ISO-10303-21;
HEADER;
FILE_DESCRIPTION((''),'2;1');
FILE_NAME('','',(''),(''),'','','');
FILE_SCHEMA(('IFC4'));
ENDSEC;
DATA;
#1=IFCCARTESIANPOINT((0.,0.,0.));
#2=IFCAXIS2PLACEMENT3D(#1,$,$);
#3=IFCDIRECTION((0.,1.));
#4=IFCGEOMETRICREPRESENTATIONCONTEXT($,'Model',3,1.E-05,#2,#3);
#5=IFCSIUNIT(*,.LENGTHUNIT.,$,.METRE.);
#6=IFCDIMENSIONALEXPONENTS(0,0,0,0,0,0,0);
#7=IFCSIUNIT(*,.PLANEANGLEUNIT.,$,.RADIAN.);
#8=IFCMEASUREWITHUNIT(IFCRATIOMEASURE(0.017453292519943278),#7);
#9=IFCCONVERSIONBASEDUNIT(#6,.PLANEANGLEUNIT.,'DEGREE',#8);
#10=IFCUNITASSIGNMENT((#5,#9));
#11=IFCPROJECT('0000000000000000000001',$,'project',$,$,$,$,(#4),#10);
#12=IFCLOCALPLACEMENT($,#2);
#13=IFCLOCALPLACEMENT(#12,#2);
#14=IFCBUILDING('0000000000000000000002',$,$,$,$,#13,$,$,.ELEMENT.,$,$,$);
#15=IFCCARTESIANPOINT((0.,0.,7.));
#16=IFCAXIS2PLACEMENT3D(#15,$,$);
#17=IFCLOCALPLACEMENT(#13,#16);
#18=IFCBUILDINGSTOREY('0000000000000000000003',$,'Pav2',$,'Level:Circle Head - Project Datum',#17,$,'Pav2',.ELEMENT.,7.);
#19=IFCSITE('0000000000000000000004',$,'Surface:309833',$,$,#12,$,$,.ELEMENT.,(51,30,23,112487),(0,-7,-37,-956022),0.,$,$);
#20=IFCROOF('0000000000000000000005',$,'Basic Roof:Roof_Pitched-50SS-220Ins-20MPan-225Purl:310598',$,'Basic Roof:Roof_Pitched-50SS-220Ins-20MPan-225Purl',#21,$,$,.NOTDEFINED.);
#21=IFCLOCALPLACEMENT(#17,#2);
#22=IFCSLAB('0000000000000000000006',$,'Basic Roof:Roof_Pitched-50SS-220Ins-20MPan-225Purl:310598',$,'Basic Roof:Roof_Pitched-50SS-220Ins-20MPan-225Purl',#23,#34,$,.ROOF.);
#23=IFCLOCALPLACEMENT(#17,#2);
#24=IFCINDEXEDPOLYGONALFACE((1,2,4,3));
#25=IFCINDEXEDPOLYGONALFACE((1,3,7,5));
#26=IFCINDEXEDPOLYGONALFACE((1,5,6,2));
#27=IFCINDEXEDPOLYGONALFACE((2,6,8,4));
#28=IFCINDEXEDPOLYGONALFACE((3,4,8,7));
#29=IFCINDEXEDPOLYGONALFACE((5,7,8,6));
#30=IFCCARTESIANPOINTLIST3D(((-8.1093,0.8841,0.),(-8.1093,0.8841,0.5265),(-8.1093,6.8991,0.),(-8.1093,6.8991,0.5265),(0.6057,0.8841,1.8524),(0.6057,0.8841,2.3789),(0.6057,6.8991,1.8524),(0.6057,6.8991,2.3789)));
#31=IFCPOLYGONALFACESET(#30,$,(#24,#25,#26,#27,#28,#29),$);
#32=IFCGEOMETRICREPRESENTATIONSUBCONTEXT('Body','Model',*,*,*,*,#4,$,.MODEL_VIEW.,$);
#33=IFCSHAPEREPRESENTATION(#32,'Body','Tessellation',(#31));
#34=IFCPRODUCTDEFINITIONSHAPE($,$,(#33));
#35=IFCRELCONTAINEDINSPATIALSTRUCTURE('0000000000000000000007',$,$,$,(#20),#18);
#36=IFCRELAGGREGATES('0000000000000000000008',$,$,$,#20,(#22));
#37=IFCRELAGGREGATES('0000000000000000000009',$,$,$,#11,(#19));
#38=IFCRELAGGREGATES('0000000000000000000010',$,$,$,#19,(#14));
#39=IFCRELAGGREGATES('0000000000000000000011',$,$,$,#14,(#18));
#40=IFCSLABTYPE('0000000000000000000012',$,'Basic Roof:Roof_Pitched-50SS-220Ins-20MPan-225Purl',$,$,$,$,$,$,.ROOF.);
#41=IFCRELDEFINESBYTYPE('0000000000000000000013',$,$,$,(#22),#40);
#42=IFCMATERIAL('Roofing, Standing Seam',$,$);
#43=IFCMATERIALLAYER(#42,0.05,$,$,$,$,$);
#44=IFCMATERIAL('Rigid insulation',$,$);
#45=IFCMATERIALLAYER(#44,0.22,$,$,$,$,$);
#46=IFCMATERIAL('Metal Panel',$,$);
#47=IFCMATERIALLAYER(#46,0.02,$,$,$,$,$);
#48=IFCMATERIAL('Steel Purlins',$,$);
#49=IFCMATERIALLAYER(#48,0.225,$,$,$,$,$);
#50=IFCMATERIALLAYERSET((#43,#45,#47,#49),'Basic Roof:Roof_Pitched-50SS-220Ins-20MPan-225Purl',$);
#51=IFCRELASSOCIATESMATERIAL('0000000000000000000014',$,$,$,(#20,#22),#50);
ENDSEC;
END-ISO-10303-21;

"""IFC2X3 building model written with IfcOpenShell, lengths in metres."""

from ifc_helpers import new_model, entity, si_unit, converted_unit, direction, frame, origin, origin_2d_with_axis, place, context, subcontext, project, spatial, rectangle, extrude, material, layer, layer_set, type_object, element, aggregate, save


model = new_model("IFC2X3")

# Units and contexts
model_context = context("Model", 3, precision=1e-05, world=origin(), true_north=direction((0.0, 1.0)))
body_context = subcontext(model_context, "Body", "Model", "MODEL_VIEW")
ifc_project = project(units=[si_unit("LENGTHUNIT", "METRE"), converted_unit("PLANEANGLEUNIT", "DEGREE", entity("IfcRatioMeasure", 0.017453292519943278), si_unit("PLANEANGLEUNIT", "RADIAN"), dimensions=[0, 0, 0, 0, 0, 0, 0])], contexts=[model_context])

# Site, building, storey
site_placement = place(None, origin())
site = spatial("IfcSite", under=ifc_project, at=site_placement, Name="Surface:309833", CompositionType="ELEMENT", RefLatitude=(51, 30, 23, 112487), RefLongitude=(0, -7, -37, -956022), RefElevation=0.0)
building_placement = place(site_placement, origin())
building = spatial("IfcBuilding", under=site, at=building_placement, CompositionType="ELEMENT")
storey_placement = place(building_placement, frame((0.0, 0.0, 7.0)))
storey = spatial("IfcBuildingStorey", under=building, at=storey_placement, Name="Pav2", ObjectType="Level:Circle Head - Project Datum", LongName="Pav2", CompositionType="ELEMENT", Elevation=7.0)

# Roof, slab
ifc_material_1 = material(Name="Roofing, Standing Seam")
ifc_layer_1 = layer(ifc_material_1, 0.05)
ifc_material_2 = material(Name="Rigid insulation")
ifc_layer_2 = layer(ifc_material_2, 0.22)
ifc_material_3 = material(Name="Metal Panel")
ifc_layer_3 = layer(ifc_material_3, 0.02)
ifc_material_4 = material(Name="Steel Purlins")
ifc_layer_4 = layer(ifc_material_4, 0.225)
ifc_layer_set = layer_set([ifc_layer_1, ifc_layer_2, ifc_layer_3, ifc_layer_4], Name="Basic Roof:Roof_Pitched-50SS-220Ins-20MPan-225Purl")
roof_placement = place(storey_placement, frame((-8.1093, 0.8841, 0.0)))
roof = element("IfcRoof", 1, at=roof_placement, inside=storey, material=ifc_layer_set, Name="Basic Roof:Roof_Pitched-50SS-220Ins-20MPan-225Purl:310598", ObjectType="Basic Roof:Roof_Pitched-50SS-220Ins-20MPan-225Purl", ShapeType="NOTDEFINED")
slab_type = type_object("IfcSlabType", Name="Basic Roof:Roof_Pitched-50SS-220Ins-20MPan-225Purl", PredefinedType="ROOF")
slab_placement = place(roof_placement, origin())
slab = element("IfcSlab", 2, at=slab_placement, type_object=slab_type, material=ifc_layer_set, Name="Basic Roof:Roof_Pitched-50SS-220Ins-20MPan-225Purl:310598", ObjectType="Basic Roof:Roof_Pitched-50SS-220Ins-20MPan-225Purl", PredefinedType="ROOF", context=body_context, shape_type="SweptSolid", body=[
    extrude(rectangle(XDim=8.9097, YDim=6.015, at=origin_2d_with_axis()), frame((4.3575, 3.0075, 0.9262), z_axis=(-0.207912, 0.0, 0.978148), x_axis=(0.978148, 0.0, 0.207912)), (0.207912, 0.0, 0.978148), 0.5265),
])
aggregate(roof, [slab])

save(model, "model.ifc")
